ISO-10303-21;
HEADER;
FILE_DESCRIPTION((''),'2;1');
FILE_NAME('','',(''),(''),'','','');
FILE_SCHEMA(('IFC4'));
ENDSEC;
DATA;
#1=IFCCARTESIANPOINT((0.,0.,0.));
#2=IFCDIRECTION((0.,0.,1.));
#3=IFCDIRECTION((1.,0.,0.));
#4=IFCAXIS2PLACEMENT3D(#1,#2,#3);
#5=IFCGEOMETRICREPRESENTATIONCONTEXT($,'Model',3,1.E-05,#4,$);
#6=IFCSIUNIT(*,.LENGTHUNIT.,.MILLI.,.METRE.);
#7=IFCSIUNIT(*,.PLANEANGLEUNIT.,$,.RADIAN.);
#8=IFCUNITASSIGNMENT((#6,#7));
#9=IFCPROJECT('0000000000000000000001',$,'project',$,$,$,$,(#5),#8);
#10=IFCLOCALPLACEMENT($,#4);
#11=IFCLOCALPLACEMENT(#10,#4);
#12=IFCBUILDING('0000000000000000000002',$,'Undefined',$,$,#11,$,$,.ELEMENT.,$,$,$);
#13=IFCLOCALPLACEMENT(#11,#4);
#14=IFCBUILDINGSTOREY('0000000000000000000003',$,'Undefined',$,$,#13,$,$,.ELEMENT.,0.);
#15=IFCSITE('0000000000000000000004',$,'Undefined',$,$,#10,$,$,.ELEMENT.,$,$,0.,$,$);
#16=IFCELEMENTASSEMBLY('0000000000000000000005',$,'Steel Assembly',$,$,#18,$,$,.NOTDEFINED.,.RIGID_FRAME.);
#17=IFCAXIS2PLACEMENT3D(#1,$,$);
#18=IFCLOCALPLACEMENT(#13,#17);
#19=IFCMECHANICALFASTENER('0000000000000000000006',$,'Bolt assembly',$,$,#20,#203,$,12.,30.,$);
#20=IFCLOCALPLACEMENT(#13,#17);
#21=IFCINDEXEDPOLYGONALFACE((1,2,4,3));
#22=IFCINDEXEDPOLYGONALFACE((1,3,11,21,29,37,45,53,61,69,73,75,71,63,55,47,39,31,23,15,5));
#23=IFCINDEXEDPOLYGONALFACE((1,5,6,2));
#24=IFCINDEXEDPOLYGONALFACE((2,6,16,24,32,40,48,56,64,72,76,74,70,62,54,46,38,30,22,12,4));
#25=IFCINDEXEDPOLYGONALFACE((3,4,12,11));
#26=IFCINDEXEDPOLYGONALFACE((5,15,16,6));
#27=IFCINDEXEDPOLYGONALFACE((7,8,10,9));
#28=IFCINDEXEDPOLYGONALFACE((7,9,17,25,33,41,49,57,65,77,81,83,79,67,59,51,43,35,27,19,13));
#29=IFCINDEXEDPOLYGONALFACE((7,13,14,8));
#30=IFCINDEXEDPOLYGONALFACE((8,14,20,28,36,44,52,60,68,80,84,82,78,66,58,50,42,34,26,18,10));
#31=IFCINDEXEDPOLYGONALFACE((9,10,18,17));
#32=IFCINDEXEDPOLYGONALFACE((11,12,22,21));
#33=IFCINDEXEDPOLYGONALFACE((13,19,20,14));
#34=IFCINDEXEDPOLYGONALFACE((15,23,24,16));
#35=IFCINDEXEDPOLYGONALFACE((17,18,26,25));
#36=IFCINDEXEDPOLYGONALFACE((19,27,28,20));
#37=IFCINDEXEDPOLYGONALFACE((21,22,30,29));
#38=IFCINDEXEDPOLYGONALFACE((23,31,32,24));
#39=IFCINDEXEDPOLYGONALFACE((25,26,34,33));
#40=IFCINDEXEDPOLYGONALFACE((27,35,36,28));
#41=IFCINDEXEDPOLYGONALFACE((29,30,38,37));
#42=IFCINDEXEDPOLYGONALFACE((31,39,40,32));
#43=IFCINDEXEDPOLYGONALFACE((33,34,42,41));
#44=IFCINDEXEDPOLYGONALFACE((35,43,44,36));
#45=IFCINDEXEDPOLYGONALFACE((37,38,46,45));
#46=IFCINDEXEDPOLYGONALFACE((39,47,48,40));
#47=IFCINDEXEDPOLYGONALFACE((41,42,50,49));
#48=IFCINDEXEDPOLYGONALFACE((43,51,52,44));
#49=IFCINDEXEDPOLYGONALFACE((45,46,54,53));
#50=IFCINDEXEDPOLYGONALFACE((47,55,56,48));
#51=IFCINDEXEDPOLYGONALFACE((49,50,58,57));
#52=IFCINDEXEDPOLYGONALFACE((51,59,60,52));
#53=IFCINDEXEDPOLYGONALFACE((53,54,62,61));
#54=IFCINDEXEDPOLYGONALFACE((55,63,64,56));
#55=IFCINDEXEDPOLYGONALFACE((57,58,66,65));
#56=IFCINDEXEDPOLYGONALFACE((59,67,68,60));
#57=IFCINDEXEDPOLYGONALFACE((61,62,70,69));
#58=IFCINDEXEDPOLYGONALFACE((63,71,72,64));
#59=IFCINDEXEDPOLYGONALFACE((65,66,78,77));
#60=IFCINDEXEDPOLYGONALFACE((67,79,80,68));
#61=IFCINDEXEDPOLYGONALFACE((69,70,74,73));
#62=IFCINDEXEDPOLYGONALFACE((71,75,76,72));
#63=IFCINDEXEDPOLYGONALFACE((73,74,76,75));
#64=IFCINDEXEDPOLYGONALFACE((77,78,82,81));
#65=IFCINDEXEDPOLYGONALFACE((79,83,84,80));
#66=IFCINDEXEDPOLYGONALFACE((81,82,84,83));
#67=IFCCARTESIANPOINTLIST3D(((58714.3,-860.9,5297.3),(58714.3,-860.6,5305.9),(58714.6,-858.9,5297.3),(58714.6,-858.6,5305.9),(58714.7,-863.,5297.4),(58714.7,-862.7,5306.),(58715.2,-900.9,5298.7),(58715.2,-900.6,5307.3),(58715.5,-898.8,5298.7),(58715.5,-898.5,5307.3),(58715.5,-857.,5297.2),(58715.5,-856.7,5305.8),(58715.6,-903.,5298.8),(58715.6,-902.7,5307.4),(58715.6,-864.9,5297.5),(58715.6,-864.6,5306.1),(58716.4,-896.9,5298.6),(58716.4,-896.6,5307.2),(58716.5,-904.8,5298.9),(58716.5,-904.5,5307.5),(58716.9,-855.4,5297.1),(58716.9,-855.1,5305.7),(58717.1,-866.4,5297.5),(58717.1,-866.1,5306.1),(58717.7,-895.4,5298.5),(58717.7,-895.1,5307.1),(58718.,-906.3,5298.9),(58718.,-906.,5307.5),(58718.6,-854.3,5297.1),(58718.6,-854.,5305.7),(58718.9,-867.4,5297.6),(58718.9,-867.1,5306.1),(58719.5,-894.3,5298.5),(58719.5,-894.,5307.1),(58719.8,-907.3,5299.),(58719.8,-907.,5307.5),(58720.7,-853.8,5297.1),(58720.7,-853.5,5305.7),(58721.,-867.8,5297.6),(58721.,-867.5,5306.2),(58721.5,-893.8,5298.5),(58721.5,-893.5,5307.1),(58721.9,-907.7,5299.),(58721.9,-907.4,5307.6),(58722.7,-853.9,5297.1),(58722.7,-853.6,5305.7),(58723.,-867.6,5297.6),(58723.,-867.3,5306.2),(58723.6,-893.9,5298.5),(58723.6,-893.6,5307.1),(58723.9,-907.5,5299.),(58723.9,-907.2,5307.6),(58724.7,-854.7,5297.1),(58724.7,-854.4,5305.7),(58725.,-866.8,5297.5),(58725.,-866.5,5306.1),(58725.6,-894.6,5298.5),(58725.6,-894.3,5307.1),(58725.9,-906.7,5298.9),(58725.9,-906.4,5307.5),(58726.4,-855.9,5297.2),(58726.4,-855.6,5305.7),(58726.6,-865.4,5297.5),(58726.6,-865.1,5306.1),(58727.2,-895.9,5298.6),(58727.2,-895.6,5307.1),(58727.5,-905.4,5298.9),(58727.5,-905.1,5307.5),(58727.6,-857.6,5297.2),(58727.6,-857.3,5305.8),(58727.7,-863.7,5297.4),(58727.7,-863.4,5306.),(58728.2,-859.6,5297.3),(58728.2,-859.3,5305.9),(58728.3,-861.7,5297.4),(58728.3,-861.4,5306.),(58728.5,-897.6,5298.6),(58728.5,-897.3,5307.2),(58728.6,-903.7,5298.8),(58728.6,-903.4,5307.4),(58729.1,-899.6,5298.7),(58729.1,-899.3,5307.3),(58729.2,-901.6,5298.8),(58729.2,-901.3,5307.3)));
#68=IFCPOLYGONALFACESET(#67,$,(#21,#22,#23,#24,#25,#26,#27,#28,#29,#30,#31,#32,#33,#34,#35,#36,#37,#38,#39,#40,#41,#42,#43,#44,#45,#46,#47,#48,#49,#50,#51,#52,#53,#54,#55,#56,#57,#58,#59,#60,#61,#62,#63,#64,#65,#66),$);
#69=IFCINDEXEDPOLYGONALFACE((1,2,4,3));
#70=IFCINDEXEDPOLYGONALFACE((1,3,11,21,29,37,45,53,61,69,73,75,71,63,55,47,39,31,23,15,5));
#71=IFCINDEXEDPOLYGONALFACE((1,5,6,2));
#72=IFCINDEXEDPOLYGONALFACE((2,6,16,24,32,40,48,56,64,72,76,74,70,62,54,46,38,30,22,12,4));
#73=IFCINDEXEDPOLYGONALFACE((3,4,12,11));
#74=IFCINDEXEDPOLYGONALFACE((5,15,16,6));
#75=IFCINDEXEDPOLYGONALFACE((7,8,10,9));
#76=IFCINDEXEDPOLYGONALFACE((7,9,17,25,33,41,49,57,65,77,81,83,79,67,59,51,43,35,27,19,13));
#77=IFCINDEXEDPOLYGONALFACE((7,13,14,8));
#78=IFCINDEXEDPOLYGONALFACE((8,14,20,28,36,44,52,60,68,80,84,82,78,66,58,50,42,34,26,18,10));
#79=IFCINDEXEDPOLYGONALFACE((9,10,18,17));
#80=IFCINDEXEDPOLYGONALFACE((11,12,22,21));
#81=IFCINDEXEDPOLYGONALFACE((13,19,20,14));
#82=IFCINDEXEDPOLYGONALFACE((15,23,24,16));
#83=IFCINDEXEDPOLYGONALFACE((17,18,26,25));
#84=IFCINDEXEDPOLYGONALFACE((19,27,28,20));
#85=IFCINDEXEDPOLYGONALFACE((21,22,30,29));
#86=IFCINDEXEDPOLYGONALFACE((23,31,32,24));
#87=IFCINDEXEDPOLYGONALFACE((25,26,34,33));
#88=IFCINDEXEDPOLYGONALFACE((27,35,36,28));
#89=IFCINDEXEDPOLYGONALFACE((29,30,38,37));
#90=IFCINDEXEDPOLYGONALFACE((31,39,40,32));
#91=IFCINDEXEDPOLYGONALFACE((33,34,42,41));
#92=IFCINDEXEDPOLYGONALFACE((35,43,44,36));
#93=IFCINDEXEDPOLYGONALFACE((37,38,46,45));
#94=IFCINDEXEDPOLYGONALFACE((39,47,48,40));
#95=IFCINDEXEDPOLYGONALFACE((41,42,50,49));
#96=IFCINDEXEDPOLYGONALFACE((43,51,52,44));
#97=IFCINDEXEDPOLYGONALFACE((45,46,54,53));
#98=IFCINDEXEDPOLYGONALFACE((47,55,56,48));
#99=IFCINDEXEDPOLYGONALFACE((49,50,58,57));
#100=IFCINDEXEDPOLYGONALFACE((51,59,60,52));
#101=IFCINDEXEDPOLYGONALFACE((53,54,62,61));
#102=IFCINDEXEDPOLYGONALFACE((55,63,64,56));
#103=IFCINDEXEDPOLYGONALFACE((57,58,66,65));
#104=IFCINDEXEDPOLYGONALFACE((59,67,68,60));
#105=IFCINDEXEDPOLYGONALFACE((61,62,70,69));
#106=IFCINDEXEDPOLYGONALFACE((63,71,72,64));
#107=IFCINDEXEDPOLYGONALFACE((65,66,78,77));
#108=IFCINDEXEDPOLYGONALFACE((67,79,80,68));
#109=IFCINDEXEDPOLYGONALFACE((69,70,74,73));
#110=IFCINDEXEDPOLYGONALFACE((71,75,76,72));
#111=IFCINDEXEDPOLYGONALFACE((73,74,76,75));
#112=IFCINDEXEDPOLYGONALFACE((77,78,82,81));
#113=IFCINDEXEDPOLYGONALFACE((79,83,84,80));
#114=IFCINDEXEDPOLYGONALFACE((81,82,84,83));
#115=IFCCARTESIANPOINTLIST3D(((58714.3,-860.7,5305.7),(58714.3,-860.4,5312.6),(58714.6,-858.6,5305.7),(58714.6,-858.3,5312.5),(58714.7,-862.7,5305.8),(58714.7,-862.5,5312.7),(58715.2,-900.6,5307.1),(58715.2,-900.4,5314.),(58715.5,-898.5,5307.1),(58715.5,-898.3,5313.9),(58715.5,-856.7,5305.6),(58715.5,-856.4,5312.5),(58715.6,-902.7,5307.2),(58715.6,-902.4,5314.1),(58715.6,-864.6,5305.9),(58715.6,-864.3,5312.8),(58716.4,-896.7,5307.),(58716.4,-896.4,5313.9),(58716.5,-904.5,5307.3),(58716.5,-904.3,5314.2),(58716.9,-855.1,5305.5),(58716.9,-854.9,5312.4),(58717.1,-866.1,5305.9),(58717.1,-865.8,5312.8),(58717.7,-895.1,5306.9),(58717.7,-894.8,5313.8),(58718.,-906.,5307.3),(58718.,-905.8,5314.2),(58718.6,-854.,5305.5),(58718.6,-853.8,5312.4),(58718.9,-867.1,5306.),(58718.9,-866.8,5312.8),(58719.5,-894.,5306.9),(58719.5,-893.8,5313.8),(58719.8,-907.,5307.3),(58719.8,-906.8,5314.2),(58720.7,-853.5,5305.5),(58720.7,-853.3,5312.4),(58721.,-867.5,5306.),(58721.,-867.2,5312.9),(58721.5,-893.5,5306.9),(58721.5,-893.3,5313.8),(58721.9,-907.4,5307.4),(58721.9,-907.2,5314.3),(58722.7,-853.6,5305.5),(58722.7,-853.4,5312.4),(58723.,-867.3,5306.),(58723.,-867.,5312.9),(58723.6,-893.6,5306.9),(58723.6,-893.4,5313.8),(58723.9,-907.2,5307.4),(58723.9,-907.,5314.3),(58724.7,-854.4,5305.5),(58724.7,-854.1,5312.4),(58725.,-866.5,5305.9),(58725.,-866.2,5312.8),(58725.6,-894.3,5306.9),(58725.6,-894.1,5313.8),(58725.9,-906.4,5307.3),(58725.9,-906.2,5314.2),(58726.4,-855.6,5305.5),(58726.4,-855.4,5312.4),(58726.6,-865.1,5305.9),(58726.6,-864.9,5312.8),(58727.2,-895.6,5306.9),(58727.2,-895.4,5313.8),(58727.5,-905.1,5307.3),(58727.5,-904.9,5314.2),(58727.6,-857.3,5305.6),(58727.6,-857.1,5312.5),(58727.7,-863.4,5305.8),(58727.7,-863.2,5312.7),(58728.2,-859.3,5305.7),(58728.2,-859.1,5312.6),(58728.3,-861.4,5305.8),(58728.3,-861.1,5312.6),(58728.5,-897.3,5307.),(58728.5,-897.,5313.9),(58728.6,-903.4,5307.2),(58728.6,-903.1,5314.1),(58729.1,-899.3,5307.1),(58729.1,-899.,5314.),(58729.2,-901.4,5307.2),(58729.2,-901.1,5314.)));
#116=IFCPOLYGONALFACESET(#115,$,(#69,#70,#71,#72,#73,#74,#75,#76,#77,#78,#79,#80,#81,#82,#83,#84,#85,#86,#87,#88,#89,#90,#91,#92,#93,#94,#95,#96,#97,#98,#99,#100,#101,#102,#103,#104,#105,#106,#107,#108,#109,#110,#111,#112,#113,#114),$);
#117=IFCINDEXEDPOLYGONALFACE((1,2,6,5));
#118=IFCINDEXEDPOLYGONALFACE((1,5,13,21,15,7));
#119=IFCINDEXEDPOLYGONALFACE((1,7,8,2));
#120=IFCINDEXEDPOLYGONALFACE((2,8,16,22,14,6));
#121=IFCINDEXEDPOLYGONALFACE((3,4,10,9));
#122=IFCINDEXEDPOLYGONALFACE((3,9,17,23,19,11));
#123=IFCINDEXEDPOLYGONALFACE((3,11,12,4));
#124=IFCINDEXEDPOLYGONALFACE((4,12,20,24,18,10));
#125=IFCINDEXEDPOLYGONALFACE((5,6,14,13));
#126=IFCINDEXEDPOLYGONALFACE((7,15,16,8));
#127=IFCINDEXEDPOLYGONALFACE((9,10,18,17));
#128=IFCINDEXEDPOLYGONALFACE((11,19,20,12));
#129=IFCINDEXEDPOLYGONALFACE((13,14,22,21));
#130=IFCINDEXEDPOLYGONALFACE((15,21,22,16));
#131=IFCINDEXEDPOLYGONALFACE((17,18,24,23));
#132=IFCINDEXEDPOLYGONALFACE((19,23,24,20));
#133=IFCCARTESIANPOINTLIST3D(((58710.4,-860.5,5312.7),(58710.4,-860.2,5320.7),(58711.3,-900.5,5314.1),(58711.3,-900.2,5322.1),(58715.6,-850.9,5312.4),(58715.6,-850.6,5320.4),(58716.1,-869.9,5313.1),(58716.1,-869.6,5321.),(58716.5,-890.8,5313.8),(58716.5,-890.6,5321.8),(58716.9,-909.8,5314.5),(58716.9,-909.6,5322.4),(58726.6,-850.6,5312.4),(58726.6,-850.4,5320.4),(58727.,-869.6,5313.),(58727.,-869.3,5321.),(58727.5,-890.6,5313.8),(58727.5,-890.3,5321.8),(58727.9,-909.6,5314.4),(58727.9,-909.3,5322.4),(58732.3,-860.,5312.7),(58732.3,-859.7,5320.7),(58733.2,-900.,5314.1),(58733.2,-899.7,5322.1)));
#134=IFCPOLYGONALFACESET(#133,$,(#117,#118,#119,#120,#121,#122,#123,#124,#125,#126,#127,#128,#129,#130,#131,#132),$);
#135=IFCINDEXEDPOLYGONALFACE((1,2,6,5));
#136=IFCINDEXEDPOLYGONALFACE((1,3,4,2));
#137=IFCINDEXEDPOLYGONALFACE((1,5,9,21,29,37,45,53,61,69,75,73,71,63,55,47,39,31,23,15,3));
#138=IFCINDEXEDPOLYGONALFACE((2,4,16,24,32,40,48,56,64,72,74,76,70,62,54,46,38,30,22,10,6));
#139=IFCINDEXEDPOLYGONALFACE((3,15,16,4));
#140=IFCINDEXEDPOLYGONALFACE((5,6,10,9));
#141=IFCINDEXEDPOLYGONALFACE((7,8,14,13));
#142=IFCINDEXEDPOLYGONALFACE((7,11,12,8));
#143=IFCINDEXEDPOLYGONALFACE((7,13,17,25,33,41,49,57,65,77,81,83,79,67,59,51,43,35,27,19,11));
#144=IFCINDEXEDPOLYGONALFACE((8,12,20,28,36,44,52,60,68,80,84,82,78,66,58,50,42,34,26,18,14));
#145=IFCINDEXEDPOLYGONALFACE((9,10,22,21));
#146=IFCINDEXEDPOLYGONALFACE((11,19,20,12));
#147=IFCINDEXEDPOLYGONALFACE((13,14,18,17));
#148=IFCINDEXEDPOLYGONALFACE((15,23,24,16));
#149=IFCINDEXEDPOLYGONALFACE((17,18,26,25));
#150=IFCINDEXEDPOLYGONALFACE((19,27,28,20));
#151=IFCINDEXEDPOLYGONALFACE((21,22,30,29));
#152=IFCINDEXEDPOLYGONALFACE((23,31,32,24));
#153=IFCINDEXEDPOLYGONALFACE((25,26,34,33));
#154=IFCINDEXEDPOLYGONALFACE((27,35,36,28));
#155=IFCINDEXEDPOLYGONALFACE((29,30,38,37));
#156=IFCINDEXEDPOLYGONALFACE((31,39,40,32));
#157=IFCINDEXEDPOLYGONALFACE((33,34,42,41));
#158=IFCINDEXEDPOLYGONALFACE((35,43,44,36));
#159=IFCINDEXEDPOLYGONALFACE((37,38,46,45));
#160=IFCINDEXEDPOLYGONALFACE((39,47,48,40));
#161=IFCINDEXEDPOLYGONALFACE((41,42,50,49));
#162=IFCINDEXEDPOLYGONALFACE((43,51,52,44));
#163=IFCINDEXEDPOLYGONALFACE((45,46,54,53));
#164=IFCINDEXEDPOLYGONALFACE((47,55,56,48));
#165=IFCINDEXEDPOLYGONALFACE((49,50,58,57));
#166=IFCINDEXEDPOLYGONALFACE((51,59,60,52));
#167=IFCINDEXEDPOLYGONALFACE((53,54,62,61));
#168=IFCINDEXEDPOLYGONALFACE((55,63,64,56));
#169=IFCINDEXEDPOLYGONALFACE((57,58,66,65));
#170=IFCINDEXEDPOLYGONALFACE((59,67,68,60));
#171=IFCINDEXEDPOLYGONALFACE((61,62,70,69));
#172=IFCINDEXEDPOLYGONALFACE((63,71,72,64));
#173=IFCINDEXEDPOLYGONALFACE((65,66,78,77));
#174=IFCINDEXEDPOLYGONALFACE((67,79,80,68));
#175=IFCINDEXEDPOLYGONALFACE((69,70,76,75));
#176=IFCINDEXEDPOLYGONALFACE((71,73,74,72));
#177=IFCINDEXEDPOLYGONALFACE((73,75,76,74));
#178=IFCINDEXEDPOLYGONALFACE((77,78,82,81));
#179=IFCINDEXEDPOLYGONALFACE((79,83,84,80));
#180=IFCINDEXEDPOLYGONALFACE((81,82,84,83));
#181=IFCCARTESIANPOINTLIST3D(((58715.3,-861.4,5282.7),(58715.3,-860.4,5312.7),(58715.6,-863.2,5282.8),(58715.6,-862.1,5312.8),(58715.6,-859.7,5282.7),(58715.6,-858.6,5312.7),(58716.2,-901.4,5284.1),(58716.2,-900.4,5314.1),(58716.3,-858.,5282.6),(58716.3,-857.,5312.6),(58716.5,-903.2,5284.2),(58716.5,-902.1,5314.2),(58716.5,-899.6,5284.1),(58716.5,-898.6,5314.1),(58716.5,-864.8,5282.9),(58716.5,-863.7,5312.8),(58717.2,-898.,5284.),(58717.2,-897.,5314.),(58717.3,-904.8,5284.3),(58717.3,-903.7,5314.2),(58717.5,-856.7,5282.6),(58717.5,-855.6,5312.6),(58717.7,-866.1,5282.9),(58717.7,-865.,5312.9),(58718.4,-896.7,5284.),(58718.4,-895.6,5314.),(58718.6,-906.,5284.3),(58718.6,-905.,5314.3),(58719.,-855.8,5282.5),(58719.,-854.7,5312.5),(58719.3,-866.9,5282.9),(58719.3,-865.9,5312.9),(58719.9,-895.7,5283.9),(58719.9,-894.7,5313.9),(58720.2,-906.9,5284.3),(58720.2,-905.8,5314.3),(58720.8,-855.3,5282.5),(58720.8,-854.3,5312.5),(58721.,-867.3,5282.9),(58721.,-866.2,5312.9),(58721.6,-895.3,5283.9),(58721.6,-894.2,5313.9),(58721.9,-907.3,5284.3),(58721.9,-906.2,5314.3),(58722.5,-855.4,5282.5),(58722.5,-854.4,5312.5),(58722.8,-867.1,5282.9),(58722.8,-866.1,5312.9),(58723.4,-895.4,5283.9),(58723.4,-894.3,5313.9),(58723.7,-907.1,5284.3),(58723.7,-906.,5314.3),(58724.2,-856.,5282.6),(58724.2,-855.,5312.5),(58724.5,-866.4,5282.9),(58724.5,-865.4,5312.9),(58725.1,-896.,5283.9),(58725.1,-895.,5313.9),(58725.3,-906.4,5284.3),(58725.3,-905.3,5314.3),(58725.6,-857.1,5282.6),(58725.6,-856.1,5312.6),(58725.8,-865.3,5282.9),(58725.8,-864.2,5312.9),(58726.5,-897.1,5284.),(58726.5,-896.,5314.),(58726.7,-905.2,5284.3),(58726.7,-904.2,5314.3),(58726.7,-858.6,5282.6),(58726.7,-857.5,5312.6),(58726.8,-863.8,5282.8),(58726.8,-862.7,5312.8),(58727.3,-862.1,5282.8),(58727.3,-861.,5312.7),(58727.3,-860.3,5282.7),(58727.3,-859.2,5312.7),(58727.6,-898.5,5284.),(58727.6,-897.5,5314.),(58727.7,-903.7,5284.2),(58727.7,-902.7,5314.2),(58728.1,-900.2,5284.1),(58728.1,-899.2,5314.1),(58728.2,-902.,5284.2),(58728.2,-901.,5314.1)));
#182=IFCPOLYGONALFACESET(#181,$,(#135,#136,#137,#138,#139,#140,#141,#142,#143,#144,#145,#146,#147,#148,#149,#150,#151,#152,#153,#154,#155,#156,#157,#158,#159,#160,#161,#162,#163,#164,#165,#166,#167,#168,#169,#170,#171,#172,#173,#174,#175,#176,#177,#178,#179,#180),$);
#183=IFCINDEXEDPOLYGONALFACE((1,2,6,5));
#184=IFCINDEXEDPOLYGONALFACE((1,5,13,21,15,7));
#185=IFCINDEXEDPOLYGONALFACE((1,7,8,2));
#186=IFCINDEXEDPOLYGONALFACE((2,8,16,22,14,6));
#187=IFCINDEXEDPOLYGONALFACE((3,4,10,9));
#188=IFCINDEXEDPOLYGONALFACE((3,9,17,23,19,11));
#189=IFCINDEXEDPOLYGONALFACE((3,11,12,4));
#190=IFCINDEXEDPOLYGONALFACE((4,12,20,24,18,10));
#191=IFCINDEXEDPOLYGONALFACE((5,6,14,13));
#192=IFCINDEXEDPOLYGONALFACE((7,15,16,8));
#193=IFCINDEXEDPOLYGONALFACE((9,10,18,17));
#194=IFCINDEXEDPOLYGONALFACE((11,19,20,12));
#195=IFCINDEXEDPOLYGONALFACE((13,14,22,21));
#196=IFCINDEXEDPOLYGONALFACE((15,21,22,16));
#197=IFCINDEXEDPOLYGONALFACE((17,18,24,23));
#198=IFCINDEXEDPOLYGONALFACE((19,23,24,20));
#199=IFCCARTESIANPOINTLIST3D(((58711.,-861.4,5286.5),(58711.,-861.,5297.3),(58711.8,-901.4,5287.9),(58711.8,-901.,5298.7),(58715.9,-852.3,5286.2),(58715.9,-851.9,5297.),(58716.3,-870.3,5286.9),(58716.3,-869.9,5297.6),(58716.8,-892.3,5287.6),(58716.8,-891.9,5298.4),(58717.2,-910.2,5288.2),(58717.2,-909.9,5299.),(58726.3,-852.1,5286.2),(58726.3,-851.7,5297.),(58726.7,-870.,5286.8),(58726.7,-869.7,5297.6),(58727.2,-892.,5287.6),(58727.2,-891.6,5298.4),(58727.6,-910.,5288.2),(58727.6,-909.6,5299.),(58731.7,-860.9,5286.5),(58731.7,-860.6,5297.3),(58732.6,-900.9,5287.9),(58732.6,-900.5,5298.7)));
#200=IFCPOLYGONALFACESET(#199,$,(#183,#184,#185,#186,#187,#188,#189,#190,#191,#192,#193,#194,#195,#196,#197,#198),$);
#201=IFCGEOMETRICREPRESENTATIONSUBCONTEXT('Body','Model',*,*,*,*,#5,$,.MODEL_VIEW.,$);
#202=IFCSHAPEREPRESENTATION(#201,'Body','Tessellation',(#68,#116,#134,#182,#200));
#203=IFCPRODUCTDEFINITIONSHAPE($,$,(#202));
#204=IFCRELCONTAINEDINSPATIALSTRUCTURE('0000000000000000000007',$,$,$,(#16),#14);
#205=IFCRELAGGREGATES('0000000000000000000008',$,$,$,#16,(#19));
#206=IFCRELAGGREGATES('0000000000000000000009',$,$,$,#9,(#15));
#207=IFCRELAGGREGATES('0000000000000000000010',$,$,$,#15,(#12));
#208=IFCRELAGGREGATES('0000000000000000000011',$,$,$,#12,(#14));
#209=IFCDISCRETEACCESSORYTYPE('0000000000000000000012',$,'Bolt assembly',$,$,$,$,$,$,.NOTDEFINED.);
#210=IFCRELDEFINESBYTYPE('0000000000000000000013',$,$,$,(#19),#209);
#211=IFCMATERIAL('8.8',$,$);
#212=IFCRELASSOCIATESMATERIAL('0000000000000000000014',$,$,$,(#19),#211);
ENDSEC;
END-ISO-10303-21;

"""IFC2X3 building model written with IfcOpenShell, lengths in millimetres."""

from ifc_helpers import new_model, si_unit, frame, origin_with_axes, origin_2d_with_axis, place, context, subcontext, project, spatial, polyline, circle, outline, extrude, source, transform, mapped, material, type_object, element, aggregate, save


model = new_model("IFC2X3")

# Units and contexts
model_context = context("Model", 3, precision=1e-05, world=origin_with_axes())
body_context = subcontext(model_context, "Body", "Model", "MODEL_VIEW")
ifc_project = project(units=[si_unit("LENGTHUNIT", "METRE", prefix="MILLI"), si_unit("PLANEANGLEUNIT", "RADIAN")], contexts=[model_context])

# Site, building, storey
site_placement = place(None, origin_with_axes())
site = spatial("IfcSite", under=ifc_project, at=site_placement, Name="Undefined", CompositionType="ELEMENT", RefElevation=0.0)
building_placement = place(site_placement, origin_with_axes())
building = spatial("IfcBuilding", under=site, at=building_placement, Name="Undefined", CompositionType="ELEMENT")
storey_placement = place(building_placement, origin_with_axes())
storey = spatial("IfcBuildingStorey", under=building, at=storey_placement, Name="Undefined", CompositionType="ELEMENT", Elevation=0.0)

# Shared definitions
discrete_accessory_type_1 = type_object("IfcDiscreteAccessoryType", Name="Bolt assembly")

# Element assembly, mechanical fastener
ifc_material_1 = material(Name="8.8")
assembly_1_placement = place(storey_placement, origin_with_axes())
assembly_1 = element("IfcElementAssembly", 1, at=assembly_1_placement, inside=storey, Name="Steel Assembly", AssemblyPlace="NOTDEFINED", PredefinedType="RIGID_FRAME")
shared_shape_1 = source(origin_with_axes(), body_context, "Body", "SweptSolid", [
    extrude(circle(Radius=7.0, at=origin_2d_with_axis()), frame((0.0, -0.1, 0.0), z_axis=(0.0, 1.0, 0.0), x_axis=(1.0, 0.0, 0.0)), (0.0, 0.0, 1.0), 8.6),
    extrude(circle(Radius=7.0, at=origin_2d_with_axis()), frame((0.0, -6.8, 0.0), z_axis=(0.0, 1.0, 0.0), x_axis=(1.0, 0.0, 0.0)), (0.0, 0.0, 1.0), 6.9),
    extrude(outline(polyline([(11.0, 0.0), (5.5, 9.5), (-5.5, 9.5), (-11.0, 0.0), (-5.5, -9.5), (5.5, -9.5), (11.0, 0.0)])), frame((0.0, -14.9, 0.0), z_axis=(0.0, 1.0, 0.0), x_axis=(1.0, 0.0, 0.0)), (0.0, 0.0, 1.0), 8.0),
    extrude(circle(Radius=6.0, at=origin_2d_with_axis()), frame((0.0, -6.9, 0.0), z_axis=(0.0, 1.0, 0.0), x_axis=(1.0, 0.0, 0.0)), (0.0, 0.0, 1.0), 30.0),
    extrude(outline(polyline([(10.4, 0.0), (5.2, 9.0), (-5.2, 9.0), (-10.4, 0.0), (-5.2, -9.0), (5.2, -9.0), (10.4, 0.0)])), frame((0.0, 8.5, 0.0), z_axis=(0.0, 1.0, 0.0), x_axis=(1.0, 0.0, 0.0)), (0.0, 0.0, 1.0), 10.8),
])
mechanical_fastener_1_placement = place(assembly_1_placement, frame((58721.8, -880.5, 5306.5), z_axis=(0.022047, -0.999145, 0.034967), x_axis=(-0.999757, -0.022033, 0.000771)))
mechanical_fastener_1 = element("IfcMechanicalFastener", 2, at=mechanical_fastener_1_placement, type_object=discrete_accessory_type_1, material=ifc_material_1, Name="Bolt assembly", NominalDiameter=12.0, NominalLength=30.0, context=body_context, shape_type="MappedRepresentation", body=[
    mapped(shared_shape_1, transform((0.0, 0.0, -20.0))),
    mapped(shared_shape_1, transform((0.0, 0.0, 20.0))),
])
aggregate(assembly_1, [mechanical_fastener_1])

save(model, "model.ifc")
